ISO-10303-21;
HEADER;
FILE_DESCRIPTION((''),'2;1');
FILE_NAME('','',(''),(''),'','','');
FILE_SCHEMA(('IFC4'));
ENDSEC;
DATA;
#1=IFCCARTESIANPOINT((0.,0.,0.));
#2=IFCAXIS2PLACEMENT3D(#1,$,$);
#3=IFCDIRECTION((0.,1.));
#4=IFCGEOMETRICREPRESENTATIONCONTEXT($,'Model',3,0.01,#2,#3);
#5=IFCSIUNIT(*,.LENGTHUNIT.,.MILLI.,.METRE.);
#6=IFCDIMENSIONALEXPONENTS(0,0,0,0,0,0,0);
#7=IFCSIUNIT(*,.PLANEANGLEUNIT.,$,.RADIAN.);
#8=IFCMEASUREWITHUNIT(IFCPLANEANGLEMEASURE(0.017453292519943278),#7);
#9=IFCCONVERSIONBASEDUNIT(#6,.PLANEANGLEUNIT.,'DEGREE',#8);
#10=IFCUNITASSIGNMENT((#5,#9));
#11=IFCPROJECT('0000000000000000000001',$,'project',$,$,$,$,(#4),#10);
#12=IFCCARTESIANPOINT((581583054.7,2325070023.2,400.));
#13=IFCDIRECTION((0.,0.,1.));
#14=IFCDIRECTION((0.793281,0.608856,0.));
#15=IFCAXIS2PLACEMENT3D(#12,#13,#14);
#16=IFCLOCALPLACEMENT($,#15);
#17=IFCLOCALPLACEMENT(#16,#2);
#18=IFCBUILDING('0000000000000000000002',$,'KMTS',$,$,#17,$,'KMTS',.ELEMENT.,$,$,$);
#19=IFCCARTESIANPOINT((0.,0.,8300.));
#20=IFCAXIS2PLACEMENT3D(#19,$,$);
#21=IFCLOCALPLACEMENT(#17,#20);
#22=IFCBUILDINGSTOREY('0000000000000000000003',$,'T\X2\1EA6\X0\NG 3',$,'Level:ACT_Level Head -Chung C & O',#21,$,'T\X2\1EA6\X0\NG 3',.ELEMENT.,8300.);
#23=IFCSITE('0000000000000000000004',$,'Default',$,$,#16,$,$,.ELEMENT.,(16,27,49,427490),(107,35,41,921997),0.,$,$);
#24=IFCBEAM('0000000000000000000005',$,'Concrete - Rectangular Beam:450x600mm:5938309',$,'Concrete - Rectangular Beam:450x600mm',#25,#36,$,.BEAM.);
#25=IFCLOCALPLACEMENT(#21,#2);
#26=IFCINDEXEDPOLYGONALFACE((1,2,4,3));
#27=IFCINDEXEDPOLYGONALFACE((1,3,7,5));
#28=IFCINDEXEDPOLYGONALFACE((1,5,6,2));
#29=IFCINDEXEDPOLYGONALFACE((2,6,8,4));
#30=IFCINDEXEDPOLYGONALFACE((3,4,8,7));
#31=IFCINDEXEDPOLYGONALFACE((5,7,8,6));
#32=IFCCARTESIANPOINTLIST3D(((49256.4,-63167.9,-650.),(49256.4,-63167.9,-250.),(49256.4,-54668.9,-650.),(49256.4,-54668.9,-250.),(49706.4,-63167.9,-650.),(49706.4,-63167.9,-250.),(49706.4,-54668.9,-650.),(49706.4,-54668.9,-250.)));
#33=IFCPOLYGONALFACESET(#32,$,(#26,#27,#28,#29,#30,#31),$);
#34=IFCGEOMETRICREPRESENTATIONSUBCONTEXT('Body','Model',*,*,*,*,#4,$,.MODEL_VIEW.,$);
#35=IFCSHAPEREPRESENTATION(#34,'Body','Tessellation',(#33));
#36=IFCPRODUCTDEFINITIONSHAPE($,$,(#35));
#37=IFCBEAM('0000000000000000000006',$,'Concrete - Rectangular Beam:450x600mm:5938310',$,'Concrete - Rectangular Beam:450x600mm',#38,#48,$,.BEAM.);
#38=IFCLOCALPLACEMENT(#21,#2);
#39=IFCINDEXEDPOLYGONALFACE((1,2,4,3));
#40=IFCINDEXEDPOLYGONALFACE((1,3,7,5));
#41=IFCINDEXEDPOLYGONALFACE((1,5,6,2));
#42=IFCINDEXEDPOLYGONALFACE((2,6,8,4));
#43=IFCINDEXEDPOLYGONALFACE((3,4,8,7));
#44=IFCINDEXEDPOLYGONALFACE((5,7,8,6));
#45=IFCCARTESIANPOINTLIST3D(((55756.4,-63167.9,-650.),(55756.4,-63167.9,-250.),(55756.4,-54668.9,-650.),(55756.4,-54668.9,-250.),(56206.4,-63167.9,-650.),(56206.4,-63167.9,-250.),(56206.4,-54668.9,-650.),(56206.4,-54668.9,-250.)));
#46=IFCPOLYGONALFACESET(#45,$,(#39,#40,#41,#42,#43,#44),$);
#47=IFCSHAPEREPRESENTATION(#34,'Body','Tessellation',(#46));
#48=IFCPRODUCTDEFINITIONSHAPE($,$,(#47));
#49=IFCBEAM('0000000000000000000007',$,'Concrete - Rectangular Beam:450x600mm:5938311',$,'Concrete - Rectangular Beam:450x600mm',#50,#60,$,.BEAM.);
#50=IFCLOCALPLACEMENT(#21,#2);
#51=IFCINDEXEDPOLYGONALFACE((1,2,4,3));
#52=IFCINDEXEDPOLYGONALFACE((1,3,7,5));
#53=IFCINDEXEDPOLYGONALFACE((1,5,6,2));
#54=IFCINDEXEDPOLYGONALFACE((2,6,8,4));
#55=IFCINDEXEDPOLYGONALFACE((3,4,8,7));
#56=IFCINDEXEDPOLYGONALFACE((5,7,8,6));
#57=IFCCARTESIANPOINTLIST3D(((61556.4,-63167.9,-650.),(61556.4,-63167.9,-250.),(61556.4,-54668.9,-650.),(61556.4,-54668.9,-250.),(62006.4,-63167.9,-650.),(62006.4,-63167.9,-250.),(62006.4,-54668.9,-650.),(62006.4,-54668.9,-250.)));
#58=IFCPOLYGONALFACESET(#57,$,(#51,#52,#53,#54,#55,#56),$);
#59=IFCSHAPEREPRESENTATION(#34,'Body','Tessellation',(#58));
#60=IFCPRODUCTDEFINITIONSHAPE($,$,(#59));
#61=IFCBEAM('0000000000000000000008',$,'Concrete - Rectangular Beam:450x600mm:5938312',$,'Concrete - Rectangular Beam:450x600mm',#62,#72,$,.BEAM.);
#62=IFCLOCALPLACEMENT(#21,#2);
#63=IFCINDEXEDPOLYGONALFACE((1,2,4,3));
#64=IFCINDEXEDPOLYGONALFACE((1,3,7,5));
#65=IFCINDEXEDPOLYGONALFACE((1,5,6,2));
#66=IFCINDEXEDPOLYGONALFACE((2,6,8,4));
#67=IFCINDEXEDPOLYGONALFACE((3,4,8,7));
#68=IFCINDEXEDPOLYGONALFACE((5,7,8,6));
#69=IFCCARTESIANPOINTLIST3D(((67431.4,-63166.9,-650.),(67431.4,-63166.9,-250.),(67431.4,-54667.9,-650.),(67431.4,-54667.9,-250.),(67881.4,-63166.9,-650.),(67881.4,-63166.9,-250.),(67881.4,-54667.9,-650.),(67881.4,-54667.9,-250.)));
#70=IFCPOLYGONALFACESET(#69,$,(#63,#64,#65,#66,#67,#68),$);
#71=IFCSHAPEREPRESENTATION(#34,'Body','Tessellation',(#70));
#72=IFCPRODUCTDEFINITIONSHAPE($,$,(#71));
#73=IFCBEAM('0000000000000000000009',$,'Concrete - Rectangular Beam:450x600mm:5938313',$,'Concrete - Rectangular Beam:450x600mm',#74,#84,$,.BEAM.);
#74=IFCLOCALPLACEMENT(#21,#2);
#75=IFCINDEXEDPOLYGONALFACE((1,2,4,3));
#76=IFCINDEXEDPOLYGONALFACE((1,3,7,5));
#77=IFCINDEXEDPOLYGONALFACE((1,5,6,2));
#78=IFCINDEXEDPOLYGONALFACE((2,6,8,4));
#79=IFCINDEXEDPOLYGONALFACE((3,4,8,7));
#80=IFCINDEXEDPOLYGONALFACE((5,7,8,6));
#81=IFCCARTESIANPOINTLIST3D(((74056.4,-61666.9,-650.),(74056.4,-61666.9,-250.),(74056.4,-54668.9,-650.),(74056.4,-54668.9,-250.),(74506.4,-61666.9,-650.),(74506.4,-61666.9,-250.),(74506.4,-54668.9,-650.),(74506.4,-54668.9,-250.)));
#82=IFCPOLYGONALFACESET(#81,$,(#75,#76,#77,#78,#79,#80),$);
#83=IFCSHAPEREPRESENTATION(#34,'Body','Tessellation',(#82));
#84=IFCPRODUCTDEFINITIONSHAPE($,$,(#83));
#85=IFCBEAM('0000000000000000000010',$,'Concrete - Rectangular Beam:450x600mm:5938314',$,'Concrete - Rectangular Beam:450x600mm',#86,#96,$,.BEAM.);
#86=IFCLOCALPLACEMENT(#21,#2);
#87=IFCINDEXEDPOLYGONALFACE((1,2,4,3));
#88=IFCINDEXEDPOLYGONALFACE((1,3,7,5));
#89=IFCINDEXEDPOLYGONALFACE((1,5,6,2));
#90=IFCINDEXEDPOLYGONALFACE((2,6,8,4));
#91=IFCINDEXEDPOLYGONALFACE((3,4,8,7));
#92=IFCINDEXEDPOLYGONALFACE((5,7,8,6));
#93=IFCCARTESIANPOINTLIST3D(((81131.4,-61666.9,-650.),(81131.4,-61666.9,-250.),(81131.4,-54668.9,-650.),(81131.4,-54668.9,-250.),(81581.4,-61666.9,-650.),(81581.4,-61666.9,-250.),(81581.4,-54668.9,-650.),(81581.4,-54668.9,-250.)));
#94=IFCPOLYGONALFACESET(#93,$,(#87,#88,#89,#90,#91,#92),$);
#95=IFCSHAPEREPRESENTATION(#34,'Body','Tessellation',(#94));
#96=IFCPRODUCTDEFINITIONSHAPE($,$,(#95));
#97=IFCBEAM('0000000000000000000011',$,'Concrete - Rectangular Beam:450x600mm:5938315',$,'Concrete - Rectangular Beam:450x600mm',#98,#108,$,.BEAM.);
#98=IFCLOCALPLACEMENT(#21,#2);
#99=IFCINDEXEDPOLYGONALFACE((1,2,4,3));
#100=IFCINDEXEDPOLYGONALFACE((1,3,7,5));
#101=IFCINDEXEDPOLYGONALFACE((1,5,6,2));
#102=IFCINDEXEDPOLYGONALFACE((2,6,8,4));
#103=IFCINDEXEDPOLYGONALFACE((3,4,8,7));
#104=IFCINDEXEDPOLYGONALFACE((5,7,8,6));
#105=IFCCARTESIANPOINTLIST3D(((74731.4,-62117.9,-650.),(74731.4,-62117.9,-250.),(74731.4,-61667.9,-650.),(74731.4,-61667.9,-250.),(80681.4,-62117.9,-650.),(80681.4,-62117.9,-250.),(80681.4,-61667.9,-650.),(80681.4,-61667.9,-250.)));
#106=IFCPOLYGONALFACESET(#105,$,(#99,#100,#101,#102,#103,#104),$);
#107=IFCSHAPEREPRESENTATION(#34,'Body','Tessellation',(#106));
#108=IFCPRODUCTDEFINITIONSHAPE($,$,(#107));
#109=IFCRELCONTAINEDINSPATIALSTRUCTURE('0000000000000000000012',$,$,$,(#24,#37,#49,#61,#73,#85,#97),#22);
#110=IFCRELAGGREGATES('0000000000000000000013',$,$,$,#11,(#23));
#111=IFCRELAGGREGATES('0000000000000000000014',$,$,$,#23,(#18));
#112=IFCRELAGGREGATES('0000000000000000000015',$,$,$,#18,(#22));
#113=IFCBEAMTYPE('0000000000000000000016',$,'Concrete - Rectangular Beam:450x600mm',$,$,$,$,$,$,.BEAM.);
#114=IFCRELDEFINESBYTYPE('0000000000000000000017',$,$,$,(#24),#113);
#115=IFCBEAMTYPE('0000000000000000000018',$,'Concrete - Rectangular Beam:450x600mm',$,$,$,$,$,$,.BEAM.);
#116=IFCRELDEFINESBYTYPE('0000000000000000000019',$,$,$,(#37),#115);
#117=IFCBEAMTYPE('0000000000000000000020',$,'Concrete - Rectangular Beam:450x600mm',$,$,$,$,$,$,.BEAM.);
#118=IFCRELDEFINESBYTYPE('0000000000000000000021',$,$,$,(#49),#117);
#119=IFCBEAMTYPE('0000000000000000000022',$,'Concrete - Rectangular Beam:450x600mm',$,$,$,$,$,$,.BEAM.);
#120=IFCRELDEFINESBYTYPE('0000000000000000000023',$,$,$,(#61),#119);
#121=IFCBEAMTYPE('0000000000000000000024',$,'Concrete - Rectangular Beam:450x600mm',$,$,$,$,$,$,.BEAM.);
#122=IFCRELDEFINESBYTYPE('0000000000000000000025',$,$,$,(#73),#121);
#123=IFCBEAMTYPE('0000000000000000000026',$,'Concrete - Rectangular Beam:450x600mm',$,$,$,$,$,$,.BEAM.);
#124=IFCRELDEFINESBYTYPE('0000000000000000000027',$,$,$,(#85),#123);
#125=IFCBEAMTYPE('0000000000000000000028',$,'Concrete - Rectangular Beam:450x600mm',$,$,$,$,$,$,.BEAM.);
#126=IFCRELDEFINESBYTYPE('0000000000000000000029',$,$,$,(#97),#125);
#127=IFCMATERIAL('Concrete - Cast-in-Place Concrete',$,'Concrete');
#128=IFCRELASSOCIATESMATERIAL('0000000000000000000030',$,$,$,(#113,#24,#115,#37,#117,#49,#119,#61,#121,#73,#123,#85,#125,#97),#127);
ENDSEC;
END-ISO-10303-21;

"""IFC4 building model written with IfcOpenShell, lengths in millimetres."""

from ifc_helpers import new_model, entity, si_unit, converted_unit, direction, frame, origin, place, context, subcontext, project, spatial, indexed_curve, outline, extrude, source, transform, mapped, material, type_object, type_shapes, element, save


model = new_model("IFC4")

# Units and contexts
model_context = context("Model", 3, precision=0.01, world=origin(), true_north=direction((0.0, 1.0)))
body_context = subcontext(model_context, "Body", "Model", "MODEL_VIEW")
ifc_project = project(units=[si_unit("LENGTHUNIT", "METRE", prefix="MILLI"), converted_unit("PLANEANGLEUNIT", "DEGREE", entity("IfcPlaneAngleMeasure", 0.017453292519943278), si_unit("PLANEANGLEUNIT", "RADIAN"), dimensions=[0, 0, 0, 0, 0, 0, 0])], contexts=[model_context])

# Site, building, storey
site_placement = place(None, frame((581583054.7, 2325070023.2, 400.0), z_axis=(0.0, 0.0, 1.0), x_axis=(0.793281, 0.608856, 0.0)))
site = spatial("IfcSite", under=ifc_project, at=site_placement, Name="Default", CompositionType="ELEMENT", RefLatitude=(16, 27, 49, 427490), RefLongitude=(107, 35, 41, 921997), RefElevation=0.0)
building_placement = place(site_placement, origin())
building = spatial("IfcBuilding", under=site, at=building_placement, Name="KMTS", LongName="KMTS", CompositionType="ELEMENT")
storey_placement = place(building_placement, frame((0.0, 0.0, 8300.0)))
storey = spatial("IfcBuildingStorey", under=building, at=storey_placement, Name="TẦNG 3", ObjectType="Level:ACT_Level Head -Chung C & O", LongName="TẦNG 3", CompositionType="ELEMENT", Elevation=8300.0)

# Beams
ifc_material = material(Name="Concrete - Cast-in-Place Concrete", Category="Concrete")
beam_type_1 = type_object("IfcBeamType", Name="Concrete - Rectangular Beam:450x600mm", PredefinedType="BEAM", material=ifc_material)
shared_shape_1 = source(origin(), body_context, "Body", "SweptSolid", [
    extrude(outline(indexed_curve([(-225.0, -200.0), (225.0, -200.0), (225.0, 200.0), (-225.0, 200.0), (-225.0, -200.0)], self_intersect=False)), frame((49481.4, -54668.9, 7850.0), z_axis=(0.0, -1.0, 0.0), x_axis=(-1.0, 0.0, 0.0)), (0.0, 0.0, 1.0), 8499.0),
])
type_shapes(beam_type_1, [shared_shape_1])
beam_1_placement = place(storey_placement, frame((0.0, 0.0, -8300.0)))
element("IfcBeam", 1, at=beam_1_placement, inside=storey, type_object=beam_type_1, material=ifc_material, Name="Concrete - Rectangular Beam:450x600mm:5938309", ObjectType="Concrete - Rectangular Beam:450x600mm", PredefinedType="BEAM", context=body_context, shape_type="MappedRepresentation", body=[
    mapped(shared_shape_1, transform((0.0, 0.0, 0.0), scale=1.0)),
])
beam_type_2 = type_object("IfcBeamType", Name="Concrete - Rectangular Beam:450x600mm", PredefinedType="BEAM", material=ifc_material)
shared_shape_2 = source(origin(), body_context, "Body", "SweptSolid", [
    extrude(outline(indexed_curve([(-225.0, -200.0), (225.0, -200.0), (225.0, 200.0), (-225.0, 200.0), (-225.0, -200.0)], self_intersect=False)), frame((55981.4, -54668.9, 7850.0), z_axis=(0.0, -1.0, 0.0), x_axis=(-1.0, 0.0, 0.0)), (0.0, 0.0, 1.0), 8499.0),
])
type_shapes(beam_type_2, [shared_shape_2])
beam_2_placement = place(storey_placement, frame((0.0, 0.0, -8300.0)))
element("IfcBeam", 2, at=beam_2_placement, inside=storey, type_object=beam_type_2, material=ifc_material, Name="Concrete - Rectangular Beam:450x600mm:5938310", ObjectType="Concrete - Rectangular Beam:450x600mm", PredefinedType="BEAM", context=body_context, shape_type="MappedRepresentation", body=[
    mapped(shared_shape_2, transform((0.0, 0.0, 0.0), scale=1.0)),
])
beam_type_3 = type_object("IfcBeamType", Name="Concrete - Rectangular Beam:450x600mm", PredefinedType="BEAM", material=ifc_material)
shared_shape_3 = source(origin(), body_context, "Body", "SweptSolid", [
    extrude(outline(indexed_curve([(-225.0, -200.0), (225.0, -200.0), (225.0, 200.0), (-225.0, 200.0), (-225.0, -200.0)], self_intersect=False)), frame((61781.4, -54668.9, 7850.0), z_axis=(0.0, -1.0, 0.0), x_axis=(-1.0, 0.0, 0.0)), (0.0, 0.0, 1.0), 8499.0),
])
type_shapes(beam_type_3, [shared_shape_3])
beam_3_placement = place(storey_placement, frame((0.0, 0.0, -8300.0)))
element("IfcBeam", 3, at=beam_3_placement, inside=storey, type_object=beam_type_3, material=ifc_material, Name="Concrete - Rectangular Beam:450x600mm:5938311", ObjectType="Concrete - Rectangular Beam:450x600mm", PredefinedType="BEAM", context=body_context, shape_type="MappedRepresentation", body=[
    mapped(shared_shape_3, transform((0.0, 0.0, 0.0), scale=1.0)),
])
beam_type_4 = type_object("IfcBeamType", Name="Concrete - Rectangular Beam:450x600mm", PredefinedType="BEAM", material=ifc_material)
shared_shape_4 = source(origin(), body_context, "Body", "SweptSolid", [
    extrude(outline(indexed_curve([(-225.0, -200.0), (225.0, -200.0), (225.0, 200.0), (-225.0, 200.0), (-225.0, -200.0)], self_intersect=False)), frame((67656.4, -54667.9, 7850.0), z_axis=(0.0, -1.0, 0.0), x_axis=(-1.0, 0.0, 0.0)), (0.0, 0.0, 1.0), 8499.0),
])
type_shapes(beam_type_4, [shared_shape_4])
beam_4_placement = place(storey_placement, frame((0.0, 0.0, -8300.0)))
element("IfcBeam", 4, at=beam_4_placement, inside=storey, type_object=beam_type_4, material=ifc_material, Name="Concrete - Rectangular Beam:450x600mm:5938312", ObjectType="Concrete - Rectangular Beam:450x600mm", PredefinedType="BEAM", context=body_context, shape_type="MappedRepresentation", body=[
    mapped(shared_shape_4, transform((0.0, 0.0, 0.0), scale=1.0)),
])
beam_type_5 = type_object("IfcBeamType", Name="Concrete - Rectangular Beam:450x600mm", PredefinedType="BEAM", material=ifc_material)
shared_shape_5 = source(origin(), body_context, "Body", "SweptSolid", [
    extrude(outline(indexed_curve([(-225.0, -200.0), (225.0, -200.0), (225.0, 200.0), (-225.0, 200.0), (-225.0, -200.0)], self_intersect=False)), frame((74281.4, -54668.9, 7850.0), z_axis=(0.0, -1.0, 0.0), x_axis=(-1.0, 0.0, 0.0)), (0.0, 0.0, 1.0), 6998.0),
])
type_shapes(beam_type_5, [shared_shape_5])
beam_5_placement = place(storey_placement, frame((0.0, 0.0, -8300.0)))
element("IfcBeam", 5, at=beam_5_placement, inside=storey, type_object=beam_type_5, material=ifc_material, Name="Concrete - Rectangular Beam:450x600mm:5938313", ObjectType="Concrete - Rectangular Beam:450x600mm", PredefinedType="BEAM", context=body_context, shape_type="MappedRepresentation", body=[
    mapped(shared_shape_5, transform((0.0, 0.0, 0.0), scale=1.0)),
])
beam_type_6 = type_object("IfcBeamType", Name="Concrete - Rectangular Beam:450x600mm", PredefinedType="BEAM", material=ifc_material)
shared_shape_6 = source(origin(), body_context, "Body", "SweptSolid", [
    extrude(outline(indexed_curve([(-225.0, -200.0), (225.0, -200.0), (225.0, 200.0), (-225.0, 200.0), (-225.0, -200.0)], self_intersect=False)), frame((81356.4, -54668.9, 7850.0), z_axis=(0.0, -1.0, 0.0), x_axis=(-1.0, 0.0, 0.0)), (0.0, 0.0, 1.0), 6998.0),
])
type_shapes(beam_type_6, [shared_shape_6])
beam_6_placement = place(storey_placement, frame((0.0, 0.0, -8300.0)))
element("IfcBeam", 6, at=beam_6_placement, inside=storey, type_object=beam_type_6, material=ifc_material, Name="Concrete - Rectangular Beam:450x600mm:5938314", ObjectType="Concrete - Rectangular Beam:450x600mm", PredefinedType="BEAM", context=body_context, shape_type="MappedRepresentation", body=[
    mapped(shared_shape_6, transform((0.0, 0.0, 0.0), scale=1.0)),
])
beam_type_7 = type_object("IfcBeamType", Name="Concrete - Rectangular Beam:450x600mm", PredefinedType="BEAM", material=ifc_material)
shared_shape_7 = source(origin(), body_context, "Body", "SweptSolid", [
    extrude(outline(indexed_curve([(-200.0, -225.0), (200.0, -225.0), (200.0, 225.0), (-200.0, 225.0), (-200.0, -225.0)], self_intersect=False)), frame((74731.4, -61892.9, 7850.0), z_axis=(1.0, 0.0, 0.0), x_axis=(0.0, 0.0, -1.0)), (0.0, 0.0, 1.0), 5950.0),
])
type_shapes(beam_type_7, [shared_shape_7])
beam_7_placement = place(storey_placement, frame((0.0, 0.0, -8300.0)))
element("IfcBeam", 7, at=beam_7_placement, inside=storey, type_object=beam_type_7, material=ifc_material, Name="Concrete - Rectangular Beam:450x600mm:5938315", ObjectType="Concrete - Rectangular Beam:450x600mm", PredefinedType="BEAM", context=body_context, shape_type="MappedRepresentation", body=[
    mapped(shared_shape_7, transform((0.0, 0.0, 0.0), scale=1.0)),
])

save(model, "model.ifc")
